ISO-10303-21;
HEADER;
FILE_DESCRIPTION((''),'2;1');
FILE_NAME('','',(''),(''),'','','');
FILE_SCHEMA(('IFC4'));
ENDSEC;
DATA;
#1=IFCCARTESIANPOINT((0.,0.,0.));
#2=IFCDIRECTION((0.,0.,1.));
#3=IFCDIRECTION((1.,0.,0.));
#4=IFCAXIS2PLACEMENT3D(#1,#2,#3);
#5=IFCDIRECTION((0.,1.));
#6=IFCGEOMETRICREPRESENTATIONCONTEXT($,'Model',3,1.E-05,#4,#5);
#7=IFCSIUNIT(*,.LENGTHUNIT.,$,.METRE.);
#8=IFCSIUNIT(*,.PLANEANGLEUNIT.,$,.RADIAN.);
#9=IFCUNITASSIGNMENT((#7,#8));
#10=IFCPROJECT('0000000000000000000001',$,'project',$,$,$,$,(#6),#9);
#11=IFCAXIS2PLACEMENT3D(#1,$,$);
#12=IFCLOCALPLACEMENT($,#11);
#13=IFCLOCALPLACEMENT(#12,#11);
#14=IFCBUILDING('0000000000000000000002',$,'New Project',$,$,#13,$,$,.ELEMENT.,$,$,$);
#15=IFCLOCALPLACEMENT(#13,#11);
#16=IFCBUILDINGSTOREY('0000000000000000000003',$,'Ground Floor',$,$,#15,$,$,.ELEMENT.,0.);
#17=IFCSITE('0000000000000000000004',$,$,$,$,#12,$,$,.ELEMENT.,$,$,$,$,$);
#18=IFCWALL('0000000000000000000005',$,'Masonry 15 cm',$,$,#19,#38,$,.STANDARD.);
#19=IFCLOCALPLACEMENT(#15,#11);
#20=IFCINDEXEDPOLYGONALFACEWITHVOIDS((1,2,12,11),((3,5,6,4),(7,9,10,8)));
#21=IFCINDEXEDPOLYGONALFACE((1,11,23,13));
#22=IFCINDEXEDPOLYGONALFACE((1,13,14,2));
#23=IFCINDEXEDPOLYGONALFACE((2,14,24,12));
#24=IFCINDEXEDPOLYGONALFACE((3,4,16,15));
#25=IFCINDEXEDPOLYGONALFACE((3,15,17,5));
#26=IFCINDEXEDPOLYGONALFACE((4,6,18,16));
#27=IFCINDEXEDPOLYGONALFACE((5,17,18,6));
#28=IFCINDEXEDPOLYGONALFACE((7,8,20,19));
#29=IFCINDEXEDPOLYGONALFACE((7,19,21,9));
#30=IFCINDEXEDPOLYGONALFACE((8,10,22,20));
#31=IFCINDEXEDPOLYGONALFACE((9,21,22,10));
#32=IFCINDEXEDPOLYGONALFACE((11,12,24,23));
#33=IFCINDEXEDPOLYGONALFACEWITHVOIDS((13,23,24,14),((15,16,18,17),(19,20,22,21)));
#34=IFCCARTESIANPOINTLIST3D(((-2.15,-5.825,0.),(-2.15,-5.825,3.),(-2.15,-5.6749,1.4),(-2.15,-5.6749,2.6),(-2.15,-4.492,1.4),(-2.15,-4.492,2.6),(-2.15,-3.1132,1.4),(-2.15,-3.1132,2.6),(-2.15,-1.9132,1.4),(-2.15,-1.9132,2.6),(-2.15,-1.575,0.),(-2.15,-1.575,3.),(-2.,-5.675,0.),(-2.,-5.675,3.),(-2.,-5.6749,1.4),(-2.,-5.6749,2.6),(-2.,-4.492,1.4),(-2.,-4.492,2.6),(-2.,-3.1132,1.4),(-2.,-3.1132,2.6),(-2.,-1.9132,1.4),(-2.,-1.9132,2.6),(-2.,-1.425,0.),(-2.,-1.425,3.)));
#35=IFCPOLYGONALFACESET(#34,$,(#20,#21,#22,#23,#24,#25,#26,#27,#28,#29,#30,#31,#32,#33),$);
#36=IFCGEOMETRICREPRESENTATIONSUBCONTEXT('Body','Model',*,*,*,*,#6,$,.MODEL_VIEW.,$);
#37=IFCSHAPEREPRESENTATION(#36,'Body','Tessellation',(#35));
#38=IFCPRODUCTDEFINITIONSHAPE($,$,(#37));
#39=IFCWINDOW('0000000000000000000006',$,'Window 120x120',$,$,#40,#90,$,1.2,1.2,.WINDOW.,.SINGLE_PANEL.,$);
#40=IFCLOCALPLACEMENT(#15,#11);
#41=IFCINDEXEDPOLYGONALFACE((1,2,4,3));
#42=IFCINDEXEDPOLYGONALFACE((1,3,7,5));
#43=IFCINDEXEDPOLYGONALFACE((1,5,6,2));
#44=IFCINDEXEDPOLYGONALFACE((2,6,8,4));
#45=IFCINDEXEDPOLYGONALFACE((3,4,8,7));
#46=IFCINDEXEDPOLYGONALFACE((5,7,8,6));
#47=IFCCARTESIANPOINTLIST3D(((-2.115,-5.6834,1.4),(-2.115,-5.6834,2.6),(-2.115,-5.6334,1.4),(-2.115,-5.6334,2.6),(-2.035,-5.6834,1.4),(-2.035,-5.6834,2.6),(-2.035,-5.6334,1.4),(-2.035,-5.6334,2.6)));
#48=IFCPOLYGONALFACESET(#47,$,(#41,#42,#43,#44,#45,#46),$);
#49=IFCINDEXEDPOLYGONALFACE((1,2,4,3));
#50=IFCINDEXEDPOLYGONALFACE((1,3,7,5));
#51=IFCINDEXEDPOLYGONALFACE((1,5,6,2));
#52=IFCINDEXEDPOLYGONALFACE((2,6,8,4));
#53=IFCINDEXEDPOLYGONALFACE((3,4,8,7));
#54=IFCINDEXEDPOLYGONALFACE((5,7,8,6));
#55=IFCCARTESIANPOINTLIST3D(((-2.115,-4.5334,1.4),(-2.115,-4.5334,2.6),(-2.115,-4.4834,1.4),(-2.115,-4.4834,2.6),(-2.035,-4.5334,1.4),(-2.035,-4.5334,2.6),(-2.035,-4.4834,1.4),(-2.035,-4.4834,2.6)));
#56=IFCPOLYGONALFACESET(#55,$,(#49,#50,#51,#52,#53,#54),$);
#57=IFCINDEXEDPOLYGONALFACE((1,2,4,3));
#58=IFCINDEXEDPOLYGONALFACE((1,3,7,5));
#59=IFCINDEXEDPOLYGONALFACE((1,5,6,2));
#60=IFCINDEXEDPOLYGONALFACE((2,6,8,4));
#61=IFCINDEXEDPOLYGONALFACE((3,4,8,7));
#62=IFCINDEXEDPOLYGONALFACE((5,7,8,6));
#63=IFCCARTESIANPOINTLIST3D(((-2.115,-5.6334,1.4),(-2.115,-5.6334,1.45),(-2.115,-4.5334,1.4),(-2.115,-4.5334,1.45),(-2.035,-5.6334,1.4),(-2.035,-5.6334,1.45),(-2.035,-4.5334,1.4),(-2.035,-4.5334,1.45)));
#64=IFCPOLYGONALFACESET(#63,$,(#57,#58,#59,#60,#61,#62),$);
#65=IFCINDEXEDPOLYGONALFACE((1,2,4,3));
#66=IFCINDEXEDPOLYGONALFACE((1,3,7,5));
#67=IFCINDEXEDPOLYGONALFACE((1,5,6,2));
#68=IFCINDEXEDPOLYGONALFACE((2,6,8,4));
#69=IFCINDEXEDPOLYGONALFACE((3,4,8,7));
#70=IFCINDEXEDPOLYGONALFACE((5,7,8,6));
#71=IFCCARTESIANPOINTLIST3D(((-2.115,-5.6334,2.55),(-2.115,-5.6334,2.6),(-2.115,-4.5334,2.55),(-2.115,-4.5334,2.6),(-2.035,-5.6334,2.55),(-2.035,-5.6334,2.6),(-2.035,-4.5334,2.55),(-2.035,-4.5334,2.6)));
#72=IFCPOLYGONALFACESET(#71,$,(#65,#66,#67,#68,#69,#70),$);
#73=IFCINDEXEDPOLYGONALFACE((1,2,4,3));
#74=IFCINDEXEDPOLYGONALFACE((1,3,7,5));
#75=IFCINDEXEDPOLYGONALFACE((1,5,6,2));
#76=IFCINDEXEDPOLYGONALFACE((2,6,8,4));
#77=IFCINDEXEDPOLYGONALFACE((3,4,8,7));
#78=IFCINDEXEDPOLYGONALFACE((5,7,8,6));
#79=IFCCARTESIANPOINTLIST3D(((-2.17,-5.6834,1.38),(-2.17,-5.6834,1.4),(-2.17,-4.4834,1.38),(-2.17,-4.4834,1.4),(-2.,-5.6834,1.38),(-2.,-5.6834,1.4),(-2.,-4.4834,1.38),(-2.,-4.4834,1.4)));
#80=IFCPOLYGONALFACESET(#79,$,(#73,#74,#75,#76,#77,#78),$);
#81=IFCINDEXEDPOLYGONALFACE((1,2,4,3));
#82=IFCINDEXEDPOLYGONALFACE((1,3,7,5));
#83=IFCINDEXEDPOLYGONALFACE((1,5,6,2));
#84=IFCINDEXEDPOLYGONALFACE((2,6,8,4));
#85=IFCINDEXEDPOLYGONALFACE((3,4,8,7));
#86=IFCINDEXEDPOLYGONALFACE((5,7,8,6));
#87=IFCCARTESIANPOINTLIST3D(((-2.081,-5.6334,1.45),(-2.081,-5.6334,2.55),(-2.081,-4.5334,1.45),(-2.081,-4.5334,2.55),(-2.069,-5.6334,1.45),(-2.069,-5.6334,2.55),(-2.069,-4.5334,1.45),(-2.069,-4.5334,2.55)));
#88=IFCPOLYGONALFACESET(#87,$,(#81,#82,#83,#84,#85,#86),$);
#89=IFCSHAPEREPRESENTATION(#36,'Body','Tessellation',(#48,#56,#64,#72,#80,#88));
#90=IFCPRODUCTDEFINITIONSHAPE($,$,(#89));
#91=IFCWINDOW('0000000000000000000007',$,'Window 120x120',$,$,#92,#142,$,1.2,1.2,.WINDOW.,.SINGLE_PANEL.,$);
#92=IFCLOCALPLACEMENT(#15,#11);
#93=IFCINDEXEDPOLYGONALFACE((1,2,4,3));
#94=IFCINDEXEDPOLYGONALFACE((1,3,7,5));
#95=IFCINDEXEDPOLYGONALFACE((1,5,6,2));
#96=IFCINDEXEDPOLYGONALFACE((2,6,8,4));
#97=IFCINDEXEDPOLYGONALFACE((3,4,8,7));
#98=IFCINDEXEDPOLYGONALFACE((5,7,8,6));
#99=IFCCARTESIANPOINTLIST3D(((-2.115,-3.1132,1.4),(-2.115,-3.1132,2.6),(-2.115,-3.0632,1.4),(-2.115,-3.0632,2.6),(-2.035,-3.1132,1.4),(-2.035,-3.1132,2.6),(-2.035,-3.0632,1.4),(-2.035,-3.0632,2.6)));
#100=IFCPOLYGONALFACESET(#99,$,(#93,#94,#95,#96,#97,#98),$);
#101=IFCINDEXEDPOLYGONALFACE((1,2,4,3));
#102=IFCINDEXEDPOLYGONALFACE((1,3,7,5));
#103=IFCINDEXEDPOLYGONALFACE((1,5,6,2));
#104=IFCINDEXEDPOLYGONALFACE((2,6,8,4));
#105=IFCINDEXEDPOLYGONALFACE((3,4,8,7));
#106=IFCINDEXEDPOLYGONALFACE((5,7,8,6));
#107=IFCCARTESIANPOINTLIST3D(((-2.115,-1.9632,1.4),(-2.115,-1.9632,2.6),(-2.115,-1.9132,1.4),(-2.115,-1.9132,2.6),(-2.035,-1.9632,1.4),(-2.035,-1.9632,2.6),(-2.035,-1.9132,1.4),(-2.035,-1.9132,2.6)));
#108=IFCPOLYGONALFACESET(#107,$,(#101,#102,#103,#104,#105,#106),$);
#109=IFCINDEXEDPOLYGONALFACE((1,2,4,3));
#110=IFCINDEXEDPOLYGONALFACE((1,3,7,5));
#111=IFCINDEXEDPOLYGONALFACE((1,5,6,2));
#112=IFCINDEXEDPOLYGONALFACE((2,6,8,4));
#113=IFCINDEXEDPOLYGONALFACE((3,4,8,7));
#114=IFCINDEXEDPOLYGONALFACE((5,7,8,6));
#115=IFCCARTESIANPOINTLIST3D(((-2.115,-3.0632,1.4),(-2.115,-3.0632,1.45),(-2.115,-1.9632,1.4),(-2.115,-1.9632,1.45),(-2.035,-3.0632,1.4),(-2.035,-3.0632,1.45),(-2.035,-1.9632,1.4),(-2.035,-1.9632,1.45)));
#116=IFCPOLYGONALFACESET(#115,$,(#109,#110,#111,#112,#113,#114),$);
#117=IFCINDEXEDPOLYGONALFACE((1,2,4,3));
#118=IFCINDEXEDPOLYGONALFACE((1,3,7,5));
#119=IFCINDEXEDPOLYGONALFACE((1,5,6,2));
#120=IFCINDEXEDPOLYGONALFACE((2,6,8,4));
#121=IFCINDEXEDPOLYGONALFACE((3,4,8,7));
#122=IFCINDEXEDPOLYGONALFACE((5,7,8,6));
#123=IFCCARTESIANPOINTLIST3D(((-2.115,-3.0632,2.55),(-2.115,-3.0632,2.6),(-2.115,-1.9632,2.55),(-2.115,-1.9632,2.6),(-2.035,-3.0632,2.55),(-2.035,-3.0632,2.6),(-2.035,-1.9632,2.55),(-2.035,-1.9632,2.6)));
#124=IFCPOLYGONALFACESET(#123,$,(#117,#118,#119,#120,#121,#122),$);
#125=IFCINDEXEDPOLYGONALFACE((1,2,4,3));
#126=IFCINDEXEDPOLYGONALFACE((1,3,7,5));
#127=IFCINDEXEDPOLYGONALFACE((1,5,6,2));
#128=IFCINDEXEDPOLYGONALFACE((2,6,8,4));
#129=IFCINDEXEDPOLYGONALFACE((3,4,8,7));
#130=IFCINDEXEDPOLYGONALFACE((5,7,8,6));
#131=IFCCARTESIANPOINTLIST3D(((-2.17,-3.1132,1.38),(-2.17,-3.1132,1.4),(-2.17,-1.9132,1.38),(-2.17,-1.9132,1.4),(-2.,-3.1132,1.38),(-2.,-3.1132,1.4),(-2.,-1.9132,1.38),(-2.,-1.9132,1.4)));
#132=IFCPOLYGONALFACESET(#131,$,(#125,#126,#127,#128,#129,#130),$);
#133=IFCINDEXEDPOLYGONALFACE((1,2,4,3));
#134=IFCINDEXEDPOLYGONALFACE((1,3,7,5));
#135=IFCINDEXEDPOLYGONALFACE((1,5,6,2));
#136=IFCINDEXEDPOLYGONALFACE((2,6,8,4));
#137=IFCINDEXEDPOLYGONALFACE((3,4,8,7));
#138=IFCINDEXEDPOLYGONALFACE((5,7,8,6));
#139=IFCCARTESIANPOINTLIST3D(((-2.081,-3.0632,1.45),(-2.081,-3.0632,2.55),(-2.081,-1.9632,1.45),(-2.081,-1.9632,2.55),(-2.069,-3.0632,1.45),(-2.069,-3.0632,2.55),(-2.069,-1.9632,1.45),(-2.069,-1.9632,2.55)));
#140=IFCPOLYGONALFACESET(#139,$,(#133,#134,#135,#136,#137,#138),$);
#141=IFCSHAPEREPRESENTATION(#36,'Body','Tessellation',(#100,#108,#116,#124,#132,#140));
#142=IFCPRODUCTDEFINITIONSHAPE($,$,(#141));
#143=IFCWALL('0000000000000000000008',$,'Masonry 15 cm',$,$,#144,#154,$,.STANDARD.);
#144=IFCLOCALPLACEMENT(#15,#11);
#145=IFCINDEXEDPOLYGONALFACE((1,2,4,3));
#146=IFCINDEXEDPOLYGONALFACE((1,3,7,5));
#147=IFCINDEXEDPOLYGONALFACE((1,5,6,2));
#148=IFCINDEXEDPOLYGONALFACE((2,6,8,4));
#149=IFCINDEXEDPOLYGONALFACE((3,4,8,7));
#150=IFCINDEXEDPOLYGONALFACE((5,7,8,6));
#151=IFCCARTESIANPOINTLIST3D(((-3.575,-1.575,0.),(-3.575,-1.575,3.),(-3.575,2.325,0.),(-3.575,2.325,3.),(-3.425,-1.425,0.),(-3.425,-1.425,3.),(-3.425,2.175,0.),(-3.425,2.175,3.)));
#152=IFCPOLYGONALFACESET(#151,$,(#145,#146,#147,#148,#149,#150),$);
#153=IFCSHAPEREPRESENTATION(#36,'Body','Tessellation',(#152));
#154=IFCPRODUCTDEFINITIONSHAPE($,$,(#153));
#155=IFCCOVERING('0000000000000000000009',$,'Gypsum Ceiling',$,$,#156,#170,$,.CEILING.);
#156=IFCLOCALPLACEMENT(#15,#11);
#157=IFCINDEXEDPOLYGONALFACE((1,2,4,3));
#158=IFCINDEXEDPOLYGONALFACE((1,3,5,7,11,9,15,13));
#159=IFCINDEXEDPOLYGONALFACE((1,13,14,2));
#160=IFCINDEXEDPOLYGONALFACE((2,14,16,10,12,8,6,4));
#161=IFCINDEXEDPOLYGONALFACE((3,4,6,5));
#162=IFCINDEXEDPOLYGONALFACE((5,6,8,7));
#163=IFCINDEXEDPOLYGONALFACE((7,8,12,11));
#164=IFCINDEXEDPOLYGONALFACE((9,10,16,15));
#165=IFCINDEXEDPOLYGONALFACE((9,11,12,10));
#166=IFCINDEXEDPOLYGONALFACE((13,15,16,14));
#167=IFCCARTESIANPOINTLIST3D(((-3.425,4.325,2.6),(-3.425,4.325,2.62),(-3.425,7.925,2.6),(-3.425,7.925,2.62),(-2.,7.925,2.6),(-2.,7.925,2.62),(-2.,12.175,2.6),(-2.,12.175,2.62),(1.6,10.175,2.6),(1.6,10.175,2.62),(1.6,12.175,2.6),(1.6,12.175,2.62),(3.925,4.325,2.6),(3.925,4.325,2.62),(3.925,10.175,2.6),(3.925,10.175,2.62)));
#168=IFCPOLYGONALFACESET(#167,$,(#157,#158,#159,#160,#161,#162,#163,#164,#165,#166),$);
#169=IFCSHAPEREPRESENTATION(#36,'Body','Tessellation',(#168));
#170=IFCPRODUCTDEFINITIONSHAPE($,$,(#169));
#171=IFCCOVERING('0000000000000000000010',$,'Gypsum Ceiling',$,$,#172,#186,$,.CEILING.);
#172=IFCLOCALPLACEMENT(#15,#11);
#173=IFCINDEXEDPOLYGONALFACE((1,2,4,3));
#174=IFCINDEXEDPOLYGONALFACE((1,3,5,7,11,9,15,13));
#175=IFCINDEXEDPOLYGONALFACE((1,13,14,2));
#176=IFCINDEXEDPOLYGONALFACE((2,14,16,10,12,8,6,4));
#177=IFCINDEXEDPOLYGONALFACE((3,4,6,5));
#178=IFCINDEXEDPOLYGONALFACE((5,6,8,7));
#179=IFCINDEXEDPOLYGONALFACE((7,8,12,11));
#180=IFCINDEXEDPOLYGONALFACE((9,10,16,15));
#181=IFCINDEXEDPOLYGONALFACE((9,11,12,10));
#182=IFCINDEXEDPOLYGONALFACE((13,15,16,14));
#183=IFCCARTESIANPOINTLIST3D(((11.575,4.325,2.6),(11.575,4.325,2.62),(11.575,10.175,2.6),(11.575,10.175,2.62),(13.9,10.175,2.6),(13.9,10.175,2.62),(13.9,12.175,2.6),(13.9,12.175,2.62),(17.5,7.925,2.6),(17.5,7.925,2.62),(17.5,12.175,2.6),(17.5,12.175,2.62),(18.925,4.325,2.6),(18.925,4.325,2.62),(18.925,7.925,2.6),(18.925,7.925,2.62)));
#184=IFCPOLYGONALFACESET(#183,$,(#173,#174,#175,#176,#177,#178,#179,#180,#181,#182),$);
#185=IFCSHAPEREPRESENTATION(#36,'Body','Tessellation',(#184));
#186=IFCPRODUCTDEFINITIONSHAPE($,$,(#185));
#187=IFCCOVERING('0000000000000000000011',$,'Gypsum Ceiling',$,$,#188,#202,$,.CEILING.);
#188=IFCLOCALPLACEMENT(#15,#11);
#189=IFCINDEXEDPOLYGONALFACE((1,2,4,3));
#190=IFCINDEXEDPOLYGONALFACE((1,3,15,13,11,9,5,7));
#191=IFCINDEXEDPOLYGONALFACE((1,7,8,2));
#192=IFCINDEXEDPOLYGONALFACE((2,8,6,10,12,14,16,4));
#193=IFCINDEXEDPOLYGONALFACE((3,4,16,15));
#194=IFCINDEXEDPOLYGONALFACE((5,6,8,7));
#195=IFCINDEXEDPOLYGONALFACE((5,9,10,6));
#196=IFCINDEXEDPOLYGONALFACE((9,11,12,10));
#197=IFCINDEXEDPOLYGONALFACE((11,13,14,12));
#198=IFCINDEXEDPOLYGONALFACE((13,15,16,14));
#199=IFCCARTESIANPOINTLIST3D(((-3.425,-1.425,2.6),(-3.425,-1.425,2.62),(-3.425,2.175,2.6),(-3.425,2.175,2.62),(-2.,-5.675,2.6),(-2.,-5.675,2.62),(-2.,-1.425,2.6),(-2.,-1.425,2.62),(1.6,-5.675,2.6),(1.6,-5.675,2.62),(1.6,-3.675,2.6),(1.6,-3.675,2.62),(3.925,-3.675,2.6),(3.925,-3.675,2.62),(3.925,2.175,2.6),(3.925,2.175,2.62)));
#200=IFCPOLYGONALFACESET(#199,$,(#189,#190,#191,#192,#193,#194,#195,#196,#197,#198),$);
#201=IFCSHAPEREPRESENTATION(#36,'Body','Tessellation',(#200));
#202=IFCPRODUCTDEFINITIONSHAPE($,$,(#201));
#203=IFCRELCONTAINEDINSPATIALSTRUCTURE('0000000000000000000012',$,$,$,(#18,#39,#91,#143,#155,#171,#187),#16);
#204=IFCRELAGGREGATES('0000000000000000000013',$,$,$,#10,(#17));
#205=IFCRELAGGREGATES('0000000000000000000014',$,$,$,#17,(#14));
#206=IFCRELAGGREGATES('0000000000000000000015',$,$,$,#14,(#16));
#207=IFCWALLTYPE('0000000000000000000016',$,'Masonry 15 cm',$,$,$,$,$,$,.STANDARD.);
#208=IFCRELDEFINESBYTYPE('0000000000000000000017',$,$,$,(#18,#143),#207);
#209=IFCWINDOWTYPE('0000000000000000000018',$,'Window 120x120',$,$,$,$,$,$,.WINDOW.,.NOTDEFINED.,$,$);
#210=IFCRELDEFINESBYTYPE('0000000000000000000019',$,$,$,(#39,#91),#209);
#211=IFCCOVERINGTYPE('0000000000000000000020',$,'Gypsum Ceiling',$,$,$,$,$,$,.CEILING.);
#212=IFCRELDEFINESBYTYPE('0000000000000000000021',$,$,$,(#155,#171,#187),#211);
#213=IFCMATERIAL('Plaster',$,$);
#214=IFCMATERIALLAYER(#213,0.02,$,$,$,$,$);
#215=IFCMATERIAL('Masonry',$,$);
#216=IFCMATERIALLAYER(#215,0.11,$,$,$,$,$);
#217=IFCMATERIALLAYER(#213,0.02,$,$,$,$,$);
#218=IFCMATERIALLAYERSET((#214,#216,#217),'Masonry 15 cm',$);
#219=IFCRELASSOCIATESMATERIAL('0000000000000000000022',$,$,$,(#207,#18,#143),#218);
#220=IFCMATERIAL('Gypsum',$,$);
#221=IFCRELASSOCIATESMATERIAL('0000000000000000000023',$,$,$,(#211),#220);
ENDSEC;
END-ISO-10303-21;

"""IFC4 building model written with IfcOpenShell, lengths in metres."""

from ifc_helpers import new_model, si_unit, direction, frame, frame_2d, origin, origin_with_axes, place, context, subcontext, project, spatial, polyline, rectangle, outline, extrude, material, layer, layer_set, layer_usage, type_object, element, fill, save


model = new_model("IFC4")

# Units and contexts
model_context = context("Model", 3, precision=1e-05, world=origin_with_axes(), true_north=direction((0.0, 1.0)))
body_context = subcontext(model_context, "Body", "Model", "MODEL_VIEW")
ifc_project = project(units=[si_unit("LENGTHUNIT", "METRE"), si_unit("PLANEANGLEUNIT", "RADIAN")], contexts=[model_context])

# Site, building, storey
site_placement = place(None, origin())
site = spatial("IfcSite", under=ifc_project, at=site_placement, CompositionType="ELEMENT")
building_placement = place(site_placement, origin())
building = spatial("IfcBuilding", under=site, at=building_placement, Name="New Project", CompositionType="ELEMENT")
storey_placement = place(building_placement, origin())
storey = spatial("IfcBuildingStorey", under=building, at=storey_placement, Name="Ground Floor", CompositionType="ELEMENT", Elevation=0.0)

# Shared definitions
ifc_material_1 = material(Name="Plaster")
ifc_layer_1 = layer(ifc_material_1, 0.02)
ifc_material_2 = material(Name="Masonry")
ifc_layer_2 = layer(ifc_material_2, 0.11)
ifc_layer_3 = layer(ifc_material_1, 0.02)
ifc_layer_set_1 = layer_set([ifc_layer_1, ifc_layer_2, ifc_layer_3], Name="Masonry 15 cm")
ifc_layer_usage_1 = layer_usage(ifc_layer_set_1, "AXIS2", "NEGATIVE", 0.075)
wall_type = type_object("IfcWallType", Name="Masonry 15 cm", PredefinedType="STANDARD", material=ifc_layer_set_1)
window_type = type_object("IfcWindowType", Name="Window 120x120", PartitioningType="NOTDEFINED", PredefinedType="WINDOW")

# Wall, openings, windows
wall_1_placement = place(storey_placement, frame((-2.075, -5.75, 0.0), z_axis=(0.0, 0.0, 1.0), x_axis=(0.0, 1.0, 0.0)))
wall_1 = element("IfcWall", 1, at=wall_1_placement, inside=storey, type_object=wall_type, material=ifc_layer_usage_1, Name="Masonry 15 cm", PredefinedType="STANDARD", context=body_context, shape_type="SweptSolid", body=[
    extrude(outline(polyline([(0.075, -0.075), (4.325, -0.075), (4.175, 0.075), (-0.075, 0.075), (0.075, -0.075)])), origin(), (0.0, 0.0, 1.0), 3.0),
])
opening_1_placement = place(wall_1_placement, frame((0.0751, 0.0, 1.4)))
opening_1 = element("IfcOpeningElement", 2, at=opening_1_placement, cuts=wall_1, PredefinedType="OPENING", context=body_context, shape_type="SweptSolid", body=[
    extrude(rectangle(XDim=1.1829, YDim=0.25, at=frame_2d((0.5915, 0.0))), origin(), (0.0, 0.0, 1.0), 1.2),
])
opening_2_placement = place(wall_1_placement, frame((2.6368, 0.0, 1.4)))
opening_2 = element("IfcOpeningElement", 3, at=opening_2_placement, cuts=wall_1, PredefinedType="OPENING", context=body_context, shape_type="SweptSolid", body=[
    extrude(rectangle(XDim=1.2, YDim=0.25, at=frame_2d((0.6, 0.0))), origin(), (0.0, 0.0, 1.0), 1.2),
])
window_1_placement = place(opening_1_placement, origin())
window_1 = element("IfcWindow", 4, at=window_1_placement, inside=storey, type_object=window_type, Name="Window 120x120", OverallHeight=1.2, OverallWidth=1.2, PartitioningType="SINGLE_PANEL", PredefinedType="WINDOW", context=body_context, shape_type="SweptSolid", body=[
    extrude(outline(polyline([(-0.0085, -0.04), (0.0415, -0.04), (0.0415, 0.04), (-0.0085, 0.04), (-0.0085, -0.04)])), origin(), (0.0, 0.0, 1.0), 1.2),
    extrude(outline(polyline([(1.1415, -0.04), (1.1915, -0.04), (1.1915, 0.04), (1.1415, 0.04), (1.1415, -0.04)])), origin(), (0.0, 0.0, 1.0), 1.2),
    extrude(outline(polyline([(0.0415, -0.04), (1.1415, -0.04), (1.1415, 0.04), (0.0415, 0.04), (0.0415, -0.04)])), origin(), (0.0, 0.0, 1.0), 0.05),
    extrude(outline(polyline([(0.0415, -0.04), (1.1415, -0.04), (1.1415, 0.04), (0.0415, 0.04), (0.0415, -0.04)])), frame((0.0, 0.0, 1.15)), (0.0, 0.0, 1.0), 0.05),
    extrude(outline(polyline([(-0.0085, -0.075), (1.1915, -0.075), (1.1915, 0.095), (-0.0085, 0.095), (-0.0085, -0.075)])), frame((0.0, 0.0, -0.02)), (0.0, 0.0, 1.0), 0.02),
    extrude(outline(polyline([(0.0415, -0.006), (1.1415, -0.006), (1.1415, 0.006), (0.0415, 0.006), (0.0415, -0.006)])), frame((0.0, 0.0, 0.05)), (0.0, 0.0, 1.0), 1.1),
])
fill(opening_1, window_1)
window_2_placement = place(opening_2_placement, origin())
window_2 = element("IfcWindow", 5, at=window_2_placement, inside=storey, type_object=window_type, Name="Window 120x120", OverallHeight=1.2, OverallWidth=1.2, PartitioningType="SINGLE_PANEL", PredefinedType="WINDOW", context=body_context, shape_type="SweptSolid", body=[
    extrude(outline(polyline([(0.0, -0.04), (0.05, -0.04), (0.05, 0.04), (0.0, 0.04), (0.0, -0.04)])), origin(), (0.0, 0.0, 1.0), 1.2),
    extrude(outline(polyline([(1.15, -0.04), (1.2, -0.04), (1.2, 0.04), (1.15, 0.04), (1.15, -0.04)])), origin(), (0.0, 0.0, 1.0), 1.2),
    extrude(outline(polyline([(0.05, -0.04), (1.15, -0.04), (1.15, 0.04), (0.05, 0.04), (0.05, -0.04)])), origin(), (0.0, 0.0, 1.0), 0.05),
    extrude(outline(polyline([(0.05, -0.04), (1.15, -0.04), (1.15, 0.04), (0.05, 0.04), (0.05, -0.04)])), frame((0.0, 0.0, 1.15)), (0.0, 0.0, 1.0), 0.05),
    extrude(outline(polyline([(0.0, -0.075), (1.2, -0.075), (1.2, 0.095), (0.0, 0.095), (0.0, -0.075)])), frame((0.0, 0.0, -0.02)), (0.0, 0.0, 1.0), 0.02),
    extrude(outline(polyline([(0.05, -0.006), (1.15, -0.006), (1.15, 0.006), (0.05, 0.006), (0.05, -0.006)])), frame((0.0, 0.0, 0.05)), (0.0, 0.0, 1.0), 1.1),
])
fill(opening_2, window_2)

# Wall
wall_2_placement = place(storey_placement, frame((-3.5, -1.5, 0.0), z_axis=(0.0, 0.0, 1.0), x_axis=(0.0, 1.0, 0.0)))
element("IfcWall", 6, at=wall_2_placement, inside=storey, type_object=wall_type, material=ifc_layer_usage_1, Name="Masonry 15 cm", PredefinedType="STANDARD", context=body_context, shape_type="SweptSolid", body=[
    extrude(outline(polyline([(0.075, -0.075), (3.675, -0.075), (3.825, 0.075), (-0.075, 0.075), (0.075, -0.075)])), origin(), (0.0, 0.0, 1.0), 3.0),
])

# Coverings
ifc_material_3 = material(Name="Gypsum")
covering_type = type_object("IfcCoveringType", Name="Gypsum Ceiling", PredefinedType="CEILING", material=ifc_material_3)
covering_1_placement = place(storey_placement, frame((0.0, 0.0, 2.6)))
element("IfcCovering", 7, at=covering_1_placement, inside=storey, type_object=covering_type, Name="Gypsum Ceiling", PredefinedType="CEILING", context=body_context, shape_type="SweptSolid", body=[
    extrude(outline(polyline([(-2.0, 7.925), (-3.425, 7.925), (-3.425, 4.325), (3.925, 4.325), (3.925, 10.175), (1.6, 10.175), (1.6, 12.175), (-2.0, 12.175), (-2.0, 7.925)])), origin(), (0.0, 0.0, 1.0), 0.02),
])
covering_2_placement = place(storey_placement, frame((0.0, 0.0, 2.6)))
element("IfcCovering", 8, at=covering_2_placement, inside=storey, type_object=covering_type, Name="Gypsum Ceiling", PredefinedType="CEILING", context=body_context, shape_type="SweptSolid", body=[
    extrude(outline(polyline([(17.5, 12.175), (13.9, 12.175), (13.9, 10.175), (11.575, 10.175), (11.575, 4.325), (18.925, 4.325), (18.925, 7.925), (17.5, 7.925), (17.5, 12.175)])), origin(), (0.0, 0.0, 1.0), 0.02),
])
covering_3_placement = place(storey_placement, frame((0.0, 0.0, 2.6)))
element("IfcCovering", 9, at=covering_3_placement, inside=storey, type_object=covering_type, Name="Gypsum Ceiling", PredefinedType="CEILING", context=body_context, shape_type="SweptSolid", body=[
    extrude(outline(polyline([(-2.0, -5.675), (1.6, -5.675), (1.6, -3.675), (3.925, -3.675), (3.925, 2.175), (-3.425, 2.175), (-3.425, -1.425), (-2.0, -1.425), (-2.0, -5.675)])), origin(), (0.0, 0.0, 1.0), 0.02),
])

save(model, "model.ifc")
